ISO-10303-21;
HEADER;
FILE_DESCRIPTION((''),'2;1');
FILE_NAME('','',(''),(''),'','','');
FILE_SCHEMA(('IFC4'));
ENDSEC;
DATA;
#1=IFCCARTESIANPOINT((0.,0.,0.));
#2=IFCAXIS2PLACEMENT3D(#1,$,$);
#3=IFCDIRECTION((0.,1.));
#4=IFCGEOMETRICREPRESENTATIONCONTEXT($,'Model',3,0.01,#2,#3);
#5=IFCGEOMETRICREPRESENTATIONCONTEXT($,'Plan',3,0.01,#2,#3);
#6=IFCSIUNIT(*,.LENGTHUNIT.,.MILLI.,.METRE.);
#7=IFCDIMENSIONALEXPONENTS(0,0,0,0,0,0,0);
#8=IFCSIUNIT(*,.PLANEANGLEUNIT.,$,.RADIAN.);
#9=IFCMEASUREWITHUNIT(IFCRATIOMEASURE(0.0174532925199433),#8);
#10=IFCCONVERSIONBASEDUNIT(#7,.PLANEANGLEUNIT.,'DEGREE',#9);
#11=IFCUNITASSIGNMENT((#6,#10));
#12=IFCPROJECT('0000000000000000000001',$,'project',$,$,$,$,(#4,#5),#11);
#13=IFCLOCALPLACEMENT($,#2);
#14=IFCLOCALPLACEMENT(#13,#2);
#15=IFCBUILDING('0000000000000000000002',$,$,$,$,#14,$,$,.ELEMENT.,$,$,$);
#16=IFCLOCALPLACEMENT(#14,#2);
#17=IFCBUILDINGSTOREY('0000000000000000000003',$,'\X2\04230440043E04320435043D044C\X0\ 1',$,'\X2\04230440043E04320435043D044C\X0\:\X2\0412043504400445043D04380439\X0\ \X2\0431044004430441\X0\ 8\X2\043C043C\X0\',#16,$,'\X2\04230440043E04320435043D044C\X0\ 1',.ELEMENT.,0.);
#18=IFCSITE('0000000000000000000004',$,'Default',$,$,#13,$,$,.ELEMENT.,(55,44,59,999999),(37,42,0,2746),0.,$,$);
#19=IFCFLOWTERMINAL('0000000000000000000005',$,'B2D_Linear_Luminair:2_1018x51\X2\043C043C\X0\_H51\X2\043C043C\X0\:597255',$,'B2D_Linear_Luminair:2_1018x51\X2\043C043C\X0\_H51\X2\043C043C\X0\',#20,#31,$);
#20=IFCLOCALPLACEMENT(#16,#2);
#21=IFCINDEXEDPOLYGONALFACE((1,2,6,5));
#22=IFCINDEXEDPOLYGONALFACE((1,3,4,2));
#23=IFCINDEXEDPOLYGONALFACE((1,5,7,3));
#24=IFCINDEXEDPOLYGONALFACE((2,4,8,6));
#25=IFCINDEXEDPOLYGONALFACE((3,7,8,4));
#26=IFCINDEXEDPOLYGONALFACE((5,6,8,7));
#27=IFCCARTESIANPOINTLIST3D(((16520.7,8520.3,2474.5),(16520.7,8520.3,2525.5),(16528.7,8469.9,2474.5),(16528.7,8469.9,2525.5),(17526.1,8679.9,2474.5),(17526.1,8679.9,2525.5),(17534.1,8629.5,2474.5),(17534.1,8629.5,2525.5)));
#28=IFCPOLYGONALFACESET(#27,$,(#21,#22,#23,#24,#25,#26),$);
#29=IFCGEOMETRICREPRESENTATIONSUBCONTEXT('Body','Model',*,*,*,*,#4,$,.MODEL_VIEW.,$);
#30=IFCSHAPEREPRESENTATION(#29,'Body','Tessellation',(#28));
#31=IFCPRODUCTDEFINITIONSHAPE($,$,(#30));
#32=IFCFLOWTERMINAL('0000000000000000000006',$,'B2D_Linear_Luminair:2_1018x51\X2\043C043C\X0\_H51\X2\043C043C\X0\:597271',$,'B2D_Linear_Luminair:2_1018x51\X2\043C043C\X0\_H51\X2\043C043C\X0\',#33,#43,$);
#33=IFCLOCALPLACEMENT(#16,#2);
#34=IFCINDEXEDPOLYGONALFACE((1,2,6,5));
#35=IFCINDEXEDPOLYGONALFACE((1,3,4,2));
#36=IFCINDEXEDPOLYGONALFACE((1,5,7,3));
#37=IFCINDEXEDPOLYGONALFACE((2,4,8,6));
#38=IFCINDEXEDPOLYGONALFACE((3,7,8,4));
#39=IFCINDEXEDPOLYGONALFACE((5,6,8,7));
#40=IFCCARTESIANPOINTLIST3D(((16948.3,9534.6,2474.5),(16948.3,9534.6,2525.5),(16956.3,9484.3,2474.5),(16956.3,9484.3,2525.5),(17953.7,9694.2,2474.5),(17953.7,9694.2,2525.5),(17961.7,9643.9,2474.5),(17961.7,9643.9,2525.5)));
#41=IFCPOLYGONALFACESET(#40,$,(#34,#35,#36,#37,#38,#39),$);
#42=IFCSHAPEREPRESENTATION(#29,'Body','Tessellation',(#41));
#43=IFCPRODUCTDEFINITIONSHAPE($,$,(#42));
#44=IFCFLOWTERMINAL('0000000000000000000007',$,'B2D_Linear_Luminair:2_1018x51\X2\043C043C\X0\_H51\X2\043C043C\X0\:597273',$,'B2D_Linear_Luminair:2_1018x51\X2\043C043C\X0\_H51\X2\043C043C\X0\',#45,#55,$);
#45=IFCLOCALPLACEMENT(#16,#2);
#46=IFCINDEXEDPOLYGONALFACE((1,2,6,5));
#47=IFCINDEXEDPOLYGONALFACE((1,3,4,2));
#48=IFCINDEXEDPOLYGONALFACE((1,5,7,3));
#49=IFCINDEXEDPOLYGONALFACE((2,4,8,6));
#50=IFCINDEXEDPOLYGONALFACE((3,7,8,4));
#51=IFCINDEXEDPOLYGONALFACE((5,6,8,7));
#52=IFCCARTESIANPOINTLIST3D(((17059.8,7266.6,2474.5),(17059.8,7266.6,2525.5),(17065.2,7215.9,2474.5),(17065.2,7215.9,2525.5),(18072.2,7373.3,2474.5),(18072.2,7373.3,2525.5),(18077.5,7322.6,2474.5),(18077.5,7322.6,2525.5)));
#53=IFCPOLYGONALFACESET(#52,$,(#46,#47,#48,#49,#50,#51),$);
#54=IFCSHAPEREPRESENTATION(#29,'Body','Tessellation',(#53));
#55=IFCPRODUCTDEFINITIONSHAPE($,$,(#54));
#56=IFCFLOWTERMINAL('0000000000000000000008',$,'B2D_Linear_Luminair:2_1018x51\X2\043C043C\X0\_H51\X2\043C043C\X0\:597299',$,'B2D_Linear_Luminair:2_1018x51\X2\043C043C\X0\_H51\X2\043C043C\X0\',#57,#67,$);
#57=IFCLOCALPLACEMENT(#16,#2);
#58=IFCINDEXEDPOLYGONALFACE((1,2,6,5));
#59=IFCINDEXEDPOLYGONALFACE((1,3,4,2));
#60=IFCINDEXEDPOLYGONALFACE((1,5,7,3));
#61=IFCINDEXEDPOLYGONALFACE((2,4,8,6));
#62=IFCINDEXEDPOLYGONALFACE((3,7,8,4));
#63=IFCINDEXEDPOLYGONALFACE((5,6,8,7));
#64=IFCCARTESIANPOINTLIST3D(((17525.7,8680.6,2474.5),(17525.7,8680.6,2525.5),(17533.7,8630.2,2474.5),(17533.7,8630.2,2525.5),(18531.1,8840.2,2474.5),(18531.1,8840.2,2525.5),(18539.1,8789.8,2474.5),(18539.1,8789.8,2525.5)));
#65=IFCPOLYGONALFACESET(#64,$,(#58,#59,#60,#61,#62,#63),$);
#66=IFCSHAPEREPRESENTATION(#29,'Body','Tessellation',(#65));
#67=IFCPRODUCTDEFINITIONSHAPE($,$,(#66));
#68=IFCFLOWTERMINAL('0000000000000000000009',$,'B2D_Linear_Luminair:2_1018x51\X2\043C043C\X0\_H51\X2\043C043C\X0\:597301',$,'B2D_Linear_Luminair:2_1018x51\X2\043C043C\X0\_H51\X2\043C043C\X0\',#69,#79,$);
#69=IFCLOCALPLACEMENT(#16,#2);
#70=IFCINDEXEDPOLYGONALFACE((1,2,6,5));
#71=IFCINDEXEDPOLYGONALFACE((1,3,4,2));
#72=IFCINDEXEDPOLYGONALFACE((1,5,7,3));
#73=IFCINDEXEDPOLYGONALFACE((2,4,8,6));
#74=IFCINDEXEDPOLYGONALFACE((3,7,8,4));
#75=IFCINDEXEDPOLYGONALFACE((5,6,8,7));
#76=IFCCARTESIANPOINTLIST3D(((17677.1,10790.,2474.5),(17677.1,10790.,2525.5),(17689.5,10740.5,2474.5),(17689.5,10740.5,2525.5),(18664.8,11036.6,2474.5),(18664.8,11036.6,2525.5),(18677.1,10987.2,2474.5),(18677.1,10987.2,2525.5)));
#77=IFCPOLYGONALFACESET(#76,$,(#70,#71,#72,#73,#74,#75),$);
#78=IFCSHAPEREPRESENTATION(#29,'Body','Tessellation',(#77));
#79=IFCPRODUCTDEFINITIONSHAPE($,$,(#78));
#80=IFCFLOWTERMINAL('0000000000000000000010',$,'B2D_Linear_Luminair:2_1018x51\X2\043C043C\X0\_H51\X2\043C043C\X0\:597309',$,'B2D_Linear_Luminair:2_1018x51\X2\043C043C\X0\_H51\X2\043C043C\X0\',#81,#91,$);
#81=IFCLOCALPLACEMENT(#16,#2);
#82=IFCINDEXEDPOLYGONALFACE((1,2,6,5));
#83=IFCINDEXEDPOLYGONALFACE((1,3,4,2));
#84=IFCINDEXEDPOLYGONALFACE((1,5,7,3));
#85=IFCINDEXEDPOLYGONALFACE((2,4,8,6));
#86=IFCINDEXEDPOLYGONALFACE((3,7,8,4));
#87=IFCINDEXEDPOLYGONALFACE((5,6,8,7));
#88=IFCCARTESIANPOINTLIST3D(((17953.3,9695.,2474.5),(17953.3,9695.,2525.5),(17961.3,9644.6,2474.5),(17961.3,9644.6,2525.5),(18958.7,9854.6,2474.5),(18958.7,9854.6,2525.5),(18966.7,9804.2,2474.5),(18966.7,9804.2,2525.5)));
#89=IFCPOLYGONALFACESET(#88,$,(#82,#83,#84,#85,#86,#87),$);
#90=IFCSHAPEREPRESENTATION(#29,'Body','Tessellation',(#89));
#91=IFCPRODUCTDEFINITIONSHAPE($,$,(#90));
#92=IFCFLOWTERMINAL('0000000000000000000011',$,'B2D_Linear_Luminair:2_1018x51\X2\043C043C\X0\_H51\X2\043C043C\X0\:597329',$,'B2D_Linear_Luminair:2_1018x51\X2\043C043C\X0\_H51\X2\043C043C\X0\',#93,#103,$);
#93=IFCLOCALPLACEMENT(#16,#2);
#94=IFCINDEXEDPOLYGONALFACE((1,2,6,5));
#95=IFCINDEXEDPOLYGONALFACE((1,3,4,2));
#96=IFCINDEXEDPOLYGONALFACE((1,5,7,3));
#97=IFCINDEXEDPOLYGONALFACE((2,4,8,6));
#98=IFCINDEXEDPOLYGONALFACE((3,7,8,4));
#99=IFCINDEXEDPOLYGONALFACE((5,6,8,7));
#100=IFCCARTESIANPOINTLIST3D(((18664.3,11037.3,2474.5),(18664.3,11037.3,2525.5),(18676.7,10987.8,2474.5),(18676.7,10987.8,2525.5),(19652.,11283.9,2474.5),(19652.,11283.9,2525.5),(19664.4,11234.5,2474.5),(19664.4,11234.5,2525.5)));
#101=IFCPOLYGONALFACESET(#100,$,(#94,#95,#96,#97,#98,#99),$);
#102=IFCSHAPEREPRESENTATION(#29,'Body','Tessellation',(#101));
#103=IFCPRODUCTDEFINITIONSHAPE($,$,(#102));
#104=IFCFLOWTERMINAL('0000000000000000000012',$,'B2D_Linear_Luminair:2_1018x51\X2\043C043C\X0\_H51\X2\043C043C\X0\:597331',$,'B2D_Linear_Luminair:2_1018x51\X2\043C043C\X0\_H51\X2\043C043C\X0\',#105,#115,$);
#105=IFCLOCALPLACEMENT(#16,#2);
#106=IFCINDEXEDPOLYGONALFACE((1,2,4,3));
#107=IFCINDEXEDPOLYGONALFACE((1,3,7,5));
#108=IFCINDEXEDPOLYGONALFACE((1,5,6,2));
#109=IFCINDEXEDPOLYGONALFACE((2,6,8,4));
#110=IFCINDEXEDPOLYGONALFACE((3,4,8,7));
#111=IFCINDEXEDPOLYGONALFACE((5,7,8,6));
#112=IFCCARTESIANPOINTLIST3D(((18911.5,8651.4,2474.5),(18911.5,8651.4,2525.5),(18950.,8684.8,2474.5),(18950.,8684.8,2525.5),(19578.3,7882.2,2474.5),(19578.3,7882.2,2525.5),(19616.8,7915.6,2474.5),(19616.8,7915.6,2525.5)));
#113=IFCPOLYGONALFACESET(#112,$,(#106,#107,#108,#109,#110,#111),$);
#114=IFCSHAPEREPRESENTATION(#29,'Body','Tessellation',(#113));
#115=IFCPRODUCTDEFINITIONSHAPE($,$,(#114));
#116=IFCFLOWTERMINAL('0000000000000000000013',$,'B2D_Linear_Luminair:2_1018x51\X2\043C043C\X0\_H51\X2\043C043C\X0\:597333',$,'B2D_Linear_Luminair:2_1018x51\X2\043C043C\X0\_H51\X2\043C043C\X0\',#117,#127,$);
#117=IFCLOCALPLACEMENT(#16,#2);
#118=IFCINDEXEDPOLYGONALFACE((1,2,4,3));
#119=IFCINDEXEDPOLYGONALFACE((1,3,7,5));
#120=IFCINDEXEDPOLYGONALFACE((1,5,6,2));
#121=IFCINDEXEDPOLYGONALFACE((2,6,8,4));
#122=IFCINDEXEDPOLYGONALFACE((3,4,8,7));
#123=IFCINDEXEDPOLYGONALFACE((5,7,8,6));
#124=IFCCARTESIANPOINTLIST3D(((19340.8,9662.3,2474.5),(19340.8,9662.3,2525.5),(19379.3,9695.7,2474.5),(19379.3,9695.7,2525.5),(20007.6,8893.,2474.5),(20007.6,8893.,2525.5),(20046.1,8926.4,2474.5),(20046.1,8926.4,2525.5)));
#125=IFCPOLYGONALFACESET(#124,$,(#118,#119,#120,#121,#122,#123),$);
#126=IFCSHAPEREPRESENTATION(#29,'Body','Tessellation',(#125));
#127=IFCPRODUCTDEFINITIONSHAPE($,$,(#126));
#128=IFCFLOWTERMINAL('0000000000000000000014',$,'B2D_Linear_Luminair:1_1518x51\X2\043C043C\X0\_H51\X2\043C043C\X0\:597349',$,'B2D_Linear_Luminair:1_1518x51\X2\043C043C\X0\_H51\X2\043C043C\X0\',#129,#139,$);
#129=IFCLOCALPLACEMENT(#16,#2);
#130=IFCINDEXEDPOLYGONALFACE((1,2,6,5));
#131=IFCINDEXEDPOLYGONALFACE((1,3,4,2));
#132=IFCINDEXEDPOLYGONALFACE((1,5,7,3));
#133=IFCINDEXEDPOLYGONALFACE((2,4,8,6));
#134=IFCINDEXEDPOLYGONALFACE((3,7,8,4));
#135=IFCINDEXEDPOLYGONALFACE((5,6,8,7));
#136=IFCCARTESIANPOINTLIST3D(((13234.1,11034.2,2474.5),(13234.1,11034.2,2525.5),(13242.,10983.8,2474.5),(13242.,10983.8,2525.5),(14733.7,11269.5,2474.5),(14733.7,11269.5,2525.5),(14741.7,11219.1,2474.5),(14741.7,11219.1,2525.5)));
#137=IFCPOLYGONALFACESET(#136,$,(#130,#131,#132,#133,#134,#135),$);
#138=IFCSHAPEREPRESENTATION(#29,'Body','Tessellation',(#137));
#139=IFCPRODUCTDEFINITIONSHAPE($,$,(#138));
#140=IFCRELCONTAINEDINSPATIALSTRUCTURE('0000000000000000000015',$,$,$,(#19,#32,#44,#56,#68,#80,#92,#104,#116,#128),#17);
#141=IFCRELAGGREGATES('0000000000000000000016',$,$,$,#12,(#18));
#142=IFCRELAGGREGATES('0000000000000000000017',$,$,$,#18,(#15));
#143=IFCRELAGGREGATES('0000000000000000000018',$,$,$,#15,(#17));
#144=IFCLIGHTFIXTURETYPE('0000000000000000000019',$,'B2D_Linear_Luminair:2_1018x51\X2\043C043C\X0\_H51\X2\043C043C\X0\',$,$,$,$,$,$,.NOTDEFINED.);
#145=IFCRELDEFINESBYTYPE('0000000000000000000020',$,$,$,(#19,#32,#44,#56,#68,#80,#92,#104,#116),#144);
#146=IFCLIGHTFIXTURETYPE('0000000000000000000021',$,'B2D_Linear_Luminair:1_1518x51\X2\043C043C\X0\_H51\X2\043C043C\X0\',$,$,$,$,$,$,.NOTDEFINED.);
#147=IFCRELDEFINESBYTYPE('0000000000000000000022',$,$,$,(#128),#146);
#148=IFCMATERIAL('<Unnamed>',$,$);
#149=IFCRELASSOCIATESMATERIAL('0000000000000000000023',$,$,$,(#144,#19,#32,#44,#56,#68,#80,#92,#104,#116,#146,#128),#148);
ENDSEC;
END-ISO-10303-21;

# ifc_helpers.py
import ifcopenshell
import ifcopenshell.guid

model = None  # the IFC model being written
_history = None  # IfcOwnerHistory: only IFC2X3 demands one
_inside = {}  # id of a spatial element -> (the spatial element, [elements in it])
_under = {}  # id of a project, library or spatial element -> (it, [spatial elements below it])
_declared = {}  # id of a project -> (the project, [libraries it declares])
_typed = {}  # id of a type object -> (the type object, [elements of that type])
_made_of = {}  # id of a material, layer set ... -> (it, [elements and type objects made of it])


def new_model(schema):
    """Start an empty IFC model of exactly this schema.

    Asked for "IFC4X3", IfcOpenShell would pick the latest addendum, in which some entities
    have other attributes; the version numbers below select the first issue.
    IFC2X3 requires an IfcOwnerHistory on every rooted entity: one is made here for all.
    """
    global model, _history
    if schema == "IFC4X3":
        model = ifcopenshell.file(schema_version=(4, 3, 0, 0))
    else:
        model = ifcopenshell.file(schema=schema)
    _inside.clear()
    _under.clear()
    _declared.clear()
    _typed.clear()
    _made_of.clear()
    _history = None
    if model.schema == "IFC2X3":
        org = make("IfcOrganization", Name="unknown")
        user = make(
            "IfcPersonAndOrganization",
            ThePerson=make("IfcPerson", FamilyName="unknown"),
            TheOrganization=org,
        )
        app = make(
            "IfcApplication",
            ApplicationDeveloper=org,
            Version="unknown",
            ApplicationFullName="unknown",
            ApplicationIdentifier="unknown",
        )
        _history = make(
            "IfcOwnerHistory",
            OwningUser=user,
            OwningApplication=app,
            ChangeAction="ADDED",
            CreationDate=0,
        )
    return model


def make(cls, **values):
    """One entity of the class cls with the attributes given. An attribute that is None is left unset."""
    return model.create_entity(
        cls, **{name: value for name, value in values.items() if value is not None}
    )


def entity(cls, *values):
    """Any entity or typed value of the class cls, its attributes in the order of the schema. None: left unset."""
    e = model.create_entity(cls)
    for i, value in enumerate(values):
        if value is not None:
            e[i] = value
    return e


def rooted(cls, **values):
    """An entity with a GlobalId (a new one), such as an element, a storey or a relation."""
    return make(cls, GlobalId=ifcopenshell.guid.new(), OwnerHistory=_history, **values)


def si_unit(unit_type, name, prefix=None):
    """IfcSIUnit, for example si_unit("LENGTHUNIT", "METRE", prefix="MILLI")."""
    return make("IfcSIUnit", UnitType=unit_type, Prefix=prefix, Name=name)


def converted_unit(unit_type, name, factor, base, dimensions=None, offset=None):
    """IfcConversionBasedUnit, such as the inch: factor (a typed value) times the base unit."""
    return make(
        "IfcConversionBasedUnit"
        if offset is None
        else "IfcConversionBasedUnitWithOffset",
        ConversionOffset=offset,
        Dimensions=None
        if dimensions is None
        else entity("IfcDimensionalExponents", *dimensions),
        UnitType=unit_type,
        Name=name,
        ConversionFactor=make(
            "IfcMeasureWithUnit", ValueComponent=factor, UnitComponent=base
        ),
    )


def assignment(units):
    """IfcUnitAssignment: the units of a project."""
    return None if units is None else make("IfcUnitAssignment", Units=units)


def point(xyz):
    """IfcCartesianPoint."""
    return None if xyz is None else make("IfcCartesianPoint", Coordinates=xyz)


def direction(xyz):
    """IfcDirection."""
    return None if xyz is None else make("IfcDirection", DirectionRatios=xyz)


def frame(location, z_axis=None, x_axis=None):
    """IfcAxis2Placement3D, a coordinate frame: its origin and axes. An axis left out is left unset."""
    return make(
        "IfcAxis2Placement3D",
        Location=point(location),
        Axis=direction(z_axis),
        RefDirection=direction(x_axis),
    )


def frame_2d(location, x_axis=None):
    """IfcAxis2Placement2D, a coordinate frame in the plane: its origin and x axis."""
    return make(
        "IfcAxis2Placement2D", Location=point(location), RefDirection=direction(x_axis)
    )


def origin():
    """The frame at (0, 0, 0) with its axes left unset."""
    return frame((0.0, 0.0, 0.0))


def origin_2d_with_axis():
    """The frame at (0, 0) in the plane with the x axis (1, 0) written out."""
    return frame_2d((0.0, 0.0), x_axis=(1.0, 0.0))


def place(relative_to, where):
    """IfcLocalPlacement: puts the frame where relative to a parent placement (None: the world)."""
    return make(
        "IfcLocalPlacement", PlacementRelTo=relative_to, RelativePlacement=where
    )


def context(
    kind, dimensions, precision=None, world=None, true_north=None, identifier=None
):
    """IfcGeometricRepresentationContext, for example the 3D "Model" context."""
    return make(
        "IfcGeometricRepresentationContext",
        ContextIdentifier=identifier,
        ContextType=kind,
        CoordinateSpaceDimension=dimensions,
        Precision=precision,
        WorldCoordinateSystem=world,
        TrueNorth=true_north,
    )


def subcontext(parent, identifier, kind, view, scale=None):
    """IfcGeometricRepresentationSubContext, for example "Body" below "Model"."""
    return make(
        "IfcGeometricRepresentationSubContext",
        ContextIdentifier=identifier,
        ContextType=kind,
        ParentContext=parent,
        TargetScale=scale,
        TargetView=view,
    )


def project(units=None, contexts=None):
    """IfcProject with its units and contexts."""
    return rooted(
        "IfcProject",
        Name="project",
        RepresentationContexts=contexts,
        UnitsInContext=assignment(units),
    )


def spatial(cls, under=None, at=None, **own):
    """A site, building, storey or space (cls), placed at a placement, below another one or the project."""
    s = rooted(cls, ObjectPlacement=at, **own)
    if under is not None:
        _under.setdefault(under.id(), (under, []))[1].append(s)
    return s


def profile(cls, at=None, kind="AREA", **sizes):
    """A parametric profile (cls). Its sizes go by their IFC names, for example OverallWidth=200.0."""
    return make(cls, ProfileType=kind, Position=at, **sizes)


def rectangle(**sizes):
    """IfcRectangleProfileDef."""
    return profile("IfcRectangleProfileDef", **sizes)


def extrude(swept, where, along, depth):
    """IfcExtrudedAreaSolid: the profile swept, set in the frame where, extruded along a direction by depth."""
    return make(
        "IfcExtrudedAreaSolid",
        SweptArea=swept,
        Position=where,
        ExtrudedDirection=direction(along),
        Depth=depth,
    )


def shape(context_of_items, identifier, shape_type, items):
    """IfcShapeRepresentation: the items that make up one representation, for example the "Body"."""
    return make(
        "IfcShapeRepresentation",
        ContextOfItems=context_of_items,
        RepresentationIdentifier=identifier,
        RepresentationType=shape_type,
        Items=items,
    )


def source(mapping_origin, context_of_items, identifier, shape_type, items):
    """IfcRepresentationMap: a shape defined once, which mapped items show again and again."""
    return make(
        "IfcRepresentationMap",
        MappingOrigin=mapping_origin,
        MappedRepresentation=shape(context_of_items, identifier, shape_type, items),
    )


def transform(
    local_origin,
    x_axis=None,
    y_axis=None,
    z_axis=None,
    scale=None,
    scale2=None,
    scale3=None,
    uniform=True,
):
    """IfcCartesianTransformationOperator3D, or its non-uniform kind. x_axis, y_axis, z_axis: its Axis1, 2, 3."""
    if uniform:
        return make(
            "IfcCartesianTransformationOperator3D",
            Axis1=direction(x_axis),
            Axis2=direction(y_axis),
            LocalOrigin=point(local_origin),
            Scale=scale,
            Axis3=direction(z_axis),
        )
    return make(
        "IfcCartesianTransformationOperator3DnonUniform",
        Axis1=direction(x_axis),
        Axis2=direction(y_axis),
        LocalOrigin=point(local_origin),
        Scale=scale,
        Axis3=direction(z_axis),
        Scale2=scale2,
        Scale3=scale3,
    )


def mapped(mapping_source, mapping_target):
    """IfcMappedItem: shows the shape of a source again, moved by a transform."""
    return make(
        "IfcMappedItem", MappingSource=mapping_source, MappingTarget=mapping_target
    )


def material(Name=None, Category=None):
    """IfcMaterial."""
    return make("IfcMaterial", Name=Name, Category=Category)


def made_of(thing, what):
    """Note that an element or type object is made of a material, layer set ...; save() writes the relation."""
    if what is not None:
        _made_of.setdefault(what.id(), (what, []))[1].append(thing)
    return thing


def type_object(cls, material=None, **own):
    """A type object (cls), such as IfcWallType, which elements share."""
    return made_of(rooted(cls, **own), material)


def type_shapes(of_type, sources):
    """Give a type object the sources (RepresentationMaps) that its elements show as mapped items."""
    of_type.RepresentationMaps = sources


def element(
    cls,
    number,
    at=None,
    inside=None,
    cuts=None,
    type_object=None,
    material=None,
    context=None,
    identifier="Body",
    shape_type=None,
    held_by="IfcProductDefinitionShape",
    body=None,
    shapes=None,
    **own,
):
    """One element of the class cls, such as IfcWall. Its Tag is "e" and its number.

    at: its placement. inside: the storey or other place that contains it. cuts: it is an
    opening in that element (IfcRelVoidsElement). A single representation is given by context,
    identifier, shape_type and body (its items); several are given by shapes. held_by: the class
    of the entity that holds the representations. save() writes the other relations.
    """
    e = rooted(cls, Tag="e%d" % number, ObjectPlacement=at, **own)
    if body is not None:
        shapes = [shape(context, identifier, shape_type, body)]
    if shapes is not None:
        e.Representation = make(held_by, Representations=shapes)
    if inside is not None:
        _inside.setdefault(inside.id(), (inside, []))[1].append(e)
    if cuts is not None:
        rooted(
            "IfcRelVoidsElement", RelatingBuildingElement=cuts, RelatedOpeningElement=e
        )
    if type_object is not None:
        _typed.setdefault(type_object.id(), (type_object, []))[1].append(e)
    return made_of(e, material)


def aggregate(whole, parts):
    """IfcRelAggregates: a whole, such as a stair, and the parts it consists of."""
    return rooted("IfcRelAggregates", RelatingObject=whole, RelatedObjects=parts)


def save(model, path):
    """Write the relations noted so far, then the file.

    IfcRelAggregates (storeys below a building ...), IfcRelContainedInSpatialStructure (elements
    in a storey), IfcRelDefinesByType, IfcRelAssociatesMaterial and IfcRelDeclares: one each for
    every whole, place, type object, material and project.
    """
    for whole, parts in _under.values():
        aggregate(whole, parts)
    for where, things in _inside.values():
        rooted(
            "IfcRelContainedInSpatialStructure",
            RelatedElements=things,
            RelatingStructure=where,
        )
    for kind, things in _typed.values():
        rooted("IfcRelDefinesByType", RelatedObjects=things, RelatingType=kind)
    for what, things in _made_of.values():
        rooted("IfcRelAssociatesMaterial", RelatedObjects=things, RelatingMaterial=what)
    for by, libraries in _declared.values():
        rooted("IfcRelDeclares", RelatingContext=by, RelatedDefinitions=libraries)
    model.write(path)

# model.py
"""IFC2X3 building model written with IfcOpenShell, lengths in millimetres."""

from ifc_helpers import new_model, entity, si_unit, converted_unit, direction, frame, origin, origin_2d_with_axis, place, context, subcontext, project, spatial, rectangle, extrude, source, transform, mapped, material, type_object, type_shapes, element, save


model = new_model("IFC2X3")

# Units and contexts
model_context = context("Model", 3, precision=0.01, world=origin(), true_north=direction((0.0, 1.0)))
plan_context = context("Plan", 3, precision=0.01, world=origin(), true_north=direction((0.0, 1.0)))
body_context = subcontext(model_context, "Body", "Model", "MODEL_VIEW")
ifc_project = project(units=[si_unit("LENGTHUNIT", "METRE", prefix="MILLI"), converted_unit("PLANEANGLEUNIT", "DEGREE", entity("IfcRatioMeasure", 0.0174532925199433), si_unit("PLANEANGLEUNIT", "RADIAN"), dimensions=[0, 0, 0, 0, 0, 0, 0])], contexts=[model_context, plan_context])

# Site, building, storey
site_placement = place(None, origin())
site = spatial("IfcSite", under=ifc_project, at=site_placement, Name="Default", CompositionType="ELEMENT", RefLatitude=(55, 44, 59, 999999), RefLongitude=(37, 42, 0, 2746), RefElevation=0.0)
building_placement = place(site_placement, origin())
building = spatial("IfcBuilding", under=site, at=building_placement, CompositionType="ELEMENT")
storey_placement = place(building_placement, origin())
storey = spatial("IfcBuildingStorey", under=building, at=storey_placement, Name="Уровень 1", ObjectType="Уровень:Верхний брус 8мм", LongName="Уровень 1", CompositionType="ELEMENT", Elevation=0.0)

# Flow terminals
ifc_material = material(Name="<Unnamed>")
light_fixture_type_1 = type_object("IfcLightFixtureType", Name="B2D_Linear_Luminair:2_1018x51мм_H51мм", PredefinedType="NOTDEFINED", material=ifc_material)
shared_shape_1 = source(origin(), body_context, "Body", "SweptSolid", [
    extrude(rectangle(XDim=1018.0, YDim=51.0, at=origin_2d_with_axis()), frame((0.0, 0.0, 0.0), z_axis=(0.0, 0.0, 1.0), x_axis=(-1.0, 0.0, 0.0)), (0.0, 0.0, 1.0), 51.0),
])
type_shapes(light_fixture_type_1, [shared_shape_1])
for number, where, z_axis, x_axis, name in (
    (1, (17027.4, 8574.9, 2525.5), (0.0, 0.0, -1.0), (0.987634, 0.156779, 0.0), "B2D_Linear_Luminair:2_1018x51мм_H51мм:597255"),
    (2, (17455.0, 9589.3, 2525.5), (0.0, 0.0, -1.0), (0.987634, 0.156779, 0.0), "B2D_Linear_Luminair:2_1018x51мм_H51мм:597271"),
    (3, (17568.7, 7294.6, 2525.5), (0.0, 0.0, -1.0), (0.994485, 0.104876, 0.0), "B2D_Linear_Luminair:2_1018x51мм_H51мм:597273"),
    (4, (18032.4, 8735.2, 2525.5), (0.0, 0.0, -1.0), (0.987634, 0.156779, 0.0), "B2D_Linear_Luminair:2_1018x51мм_H51мм:597299"),
    (5, (18177.1, 10888.6, 2525.5), (0.0, 0.0, -1.0), (0.970211, 0.242261, 0.0), "B2D_Linear_Luminair:2_1018x51мм_H51мм:597301"),
    (6, (18460.0, 9749.6, 2525.5), (0.0, 0.0, -1.0), (0.987634, 0.156779, 0.0), "B2D_Linear_Luminair:2_1018x51мм_H51мм:597309"),
    (7, (19164.4, 11135.9, 2525.5), (0.0, 0.0, -1.0), (0.970211, 0.242261, 0.0), "B2D_Linear_Luminair:2_1018x51мм_H51мм:597329"),
    (8, (19264.1, 8283.5, 2525.5), (0.0, 0.0, -1.0), (0.655005, -0.755625, 0.0), "B2D_Linear_Luminair:2_1018x51мм_H51мм:597331"),
    (9, (19693.4, 9294.3, 2525.5), (0.0, 0.0, -1.0), (0.655005, -0.755625, 0.0), "B2D_Linear_Luminair:2_1018x51мм_H51мм:597333"),
):
    element("IfcFlowTerminal", number, at=place(storey_placement, frame(where, z_axis=z_axis, x_axis=x_axis)), inside=storey, type_object=light_fixture_type_1, material=ifc_material, Name=name, ObjectType="B2D_Linear_Luminair:2_1018x51мм_H51мм", context=body_context, shape_type="MappedRepresentation", body=[
        mapped(shared_shape_1, transform((0.0, 0.0, 0.0), scale=1.0)),
    ])
light_fixture_type_2 = type_object("IfcLightFixtureType", Name="B2D_Linear_Luminair:1_1518x51мм_H51мм", PredefinedType="NOTDEFINED", material=ifc_material)
shared_shape_2 = source(origin(), body_context, "Body", "SweptSolid", [
    extrude(rectangle(XDim=1518.0, YDim=51.0, at=origin_2d_with_axis()), frame((0.0, 0.0, 0.0), z_axis=(0.0, 0.0, 1.0), x_axis=(-1.0, 0.0, 0.0)), (0.0, 0.0, 1.0), 51.0),
])
type_shapes(light_fixture_type_2, [shared_shape_2])
flow_terminal_placement = place(storey_placement, frame((13987.9, 11126.6, 2525.5), z_axis=(0.0, 0.0, -1.0), x_axis=(0.987906, 0.155055, 0.0)))
element("IfcFlowTerminal", 10, at=flow_terminal_placement, inside=storey, type_object=light_fixture_type_2, material=ifc_material, Name="B2D_Linear_Luminair:1_1518x51мм_H51мм:597349", ObjectType="B2D_Linear_Luminair:1_1518x51мм_H51мм", context=body_context, shape_type="MappedRepresentation", body=[
    mapped(shared_shape_2, transform((0.0, 0.0, 0.0), scale=1.0)),
])

save(model, "model.ifc")
